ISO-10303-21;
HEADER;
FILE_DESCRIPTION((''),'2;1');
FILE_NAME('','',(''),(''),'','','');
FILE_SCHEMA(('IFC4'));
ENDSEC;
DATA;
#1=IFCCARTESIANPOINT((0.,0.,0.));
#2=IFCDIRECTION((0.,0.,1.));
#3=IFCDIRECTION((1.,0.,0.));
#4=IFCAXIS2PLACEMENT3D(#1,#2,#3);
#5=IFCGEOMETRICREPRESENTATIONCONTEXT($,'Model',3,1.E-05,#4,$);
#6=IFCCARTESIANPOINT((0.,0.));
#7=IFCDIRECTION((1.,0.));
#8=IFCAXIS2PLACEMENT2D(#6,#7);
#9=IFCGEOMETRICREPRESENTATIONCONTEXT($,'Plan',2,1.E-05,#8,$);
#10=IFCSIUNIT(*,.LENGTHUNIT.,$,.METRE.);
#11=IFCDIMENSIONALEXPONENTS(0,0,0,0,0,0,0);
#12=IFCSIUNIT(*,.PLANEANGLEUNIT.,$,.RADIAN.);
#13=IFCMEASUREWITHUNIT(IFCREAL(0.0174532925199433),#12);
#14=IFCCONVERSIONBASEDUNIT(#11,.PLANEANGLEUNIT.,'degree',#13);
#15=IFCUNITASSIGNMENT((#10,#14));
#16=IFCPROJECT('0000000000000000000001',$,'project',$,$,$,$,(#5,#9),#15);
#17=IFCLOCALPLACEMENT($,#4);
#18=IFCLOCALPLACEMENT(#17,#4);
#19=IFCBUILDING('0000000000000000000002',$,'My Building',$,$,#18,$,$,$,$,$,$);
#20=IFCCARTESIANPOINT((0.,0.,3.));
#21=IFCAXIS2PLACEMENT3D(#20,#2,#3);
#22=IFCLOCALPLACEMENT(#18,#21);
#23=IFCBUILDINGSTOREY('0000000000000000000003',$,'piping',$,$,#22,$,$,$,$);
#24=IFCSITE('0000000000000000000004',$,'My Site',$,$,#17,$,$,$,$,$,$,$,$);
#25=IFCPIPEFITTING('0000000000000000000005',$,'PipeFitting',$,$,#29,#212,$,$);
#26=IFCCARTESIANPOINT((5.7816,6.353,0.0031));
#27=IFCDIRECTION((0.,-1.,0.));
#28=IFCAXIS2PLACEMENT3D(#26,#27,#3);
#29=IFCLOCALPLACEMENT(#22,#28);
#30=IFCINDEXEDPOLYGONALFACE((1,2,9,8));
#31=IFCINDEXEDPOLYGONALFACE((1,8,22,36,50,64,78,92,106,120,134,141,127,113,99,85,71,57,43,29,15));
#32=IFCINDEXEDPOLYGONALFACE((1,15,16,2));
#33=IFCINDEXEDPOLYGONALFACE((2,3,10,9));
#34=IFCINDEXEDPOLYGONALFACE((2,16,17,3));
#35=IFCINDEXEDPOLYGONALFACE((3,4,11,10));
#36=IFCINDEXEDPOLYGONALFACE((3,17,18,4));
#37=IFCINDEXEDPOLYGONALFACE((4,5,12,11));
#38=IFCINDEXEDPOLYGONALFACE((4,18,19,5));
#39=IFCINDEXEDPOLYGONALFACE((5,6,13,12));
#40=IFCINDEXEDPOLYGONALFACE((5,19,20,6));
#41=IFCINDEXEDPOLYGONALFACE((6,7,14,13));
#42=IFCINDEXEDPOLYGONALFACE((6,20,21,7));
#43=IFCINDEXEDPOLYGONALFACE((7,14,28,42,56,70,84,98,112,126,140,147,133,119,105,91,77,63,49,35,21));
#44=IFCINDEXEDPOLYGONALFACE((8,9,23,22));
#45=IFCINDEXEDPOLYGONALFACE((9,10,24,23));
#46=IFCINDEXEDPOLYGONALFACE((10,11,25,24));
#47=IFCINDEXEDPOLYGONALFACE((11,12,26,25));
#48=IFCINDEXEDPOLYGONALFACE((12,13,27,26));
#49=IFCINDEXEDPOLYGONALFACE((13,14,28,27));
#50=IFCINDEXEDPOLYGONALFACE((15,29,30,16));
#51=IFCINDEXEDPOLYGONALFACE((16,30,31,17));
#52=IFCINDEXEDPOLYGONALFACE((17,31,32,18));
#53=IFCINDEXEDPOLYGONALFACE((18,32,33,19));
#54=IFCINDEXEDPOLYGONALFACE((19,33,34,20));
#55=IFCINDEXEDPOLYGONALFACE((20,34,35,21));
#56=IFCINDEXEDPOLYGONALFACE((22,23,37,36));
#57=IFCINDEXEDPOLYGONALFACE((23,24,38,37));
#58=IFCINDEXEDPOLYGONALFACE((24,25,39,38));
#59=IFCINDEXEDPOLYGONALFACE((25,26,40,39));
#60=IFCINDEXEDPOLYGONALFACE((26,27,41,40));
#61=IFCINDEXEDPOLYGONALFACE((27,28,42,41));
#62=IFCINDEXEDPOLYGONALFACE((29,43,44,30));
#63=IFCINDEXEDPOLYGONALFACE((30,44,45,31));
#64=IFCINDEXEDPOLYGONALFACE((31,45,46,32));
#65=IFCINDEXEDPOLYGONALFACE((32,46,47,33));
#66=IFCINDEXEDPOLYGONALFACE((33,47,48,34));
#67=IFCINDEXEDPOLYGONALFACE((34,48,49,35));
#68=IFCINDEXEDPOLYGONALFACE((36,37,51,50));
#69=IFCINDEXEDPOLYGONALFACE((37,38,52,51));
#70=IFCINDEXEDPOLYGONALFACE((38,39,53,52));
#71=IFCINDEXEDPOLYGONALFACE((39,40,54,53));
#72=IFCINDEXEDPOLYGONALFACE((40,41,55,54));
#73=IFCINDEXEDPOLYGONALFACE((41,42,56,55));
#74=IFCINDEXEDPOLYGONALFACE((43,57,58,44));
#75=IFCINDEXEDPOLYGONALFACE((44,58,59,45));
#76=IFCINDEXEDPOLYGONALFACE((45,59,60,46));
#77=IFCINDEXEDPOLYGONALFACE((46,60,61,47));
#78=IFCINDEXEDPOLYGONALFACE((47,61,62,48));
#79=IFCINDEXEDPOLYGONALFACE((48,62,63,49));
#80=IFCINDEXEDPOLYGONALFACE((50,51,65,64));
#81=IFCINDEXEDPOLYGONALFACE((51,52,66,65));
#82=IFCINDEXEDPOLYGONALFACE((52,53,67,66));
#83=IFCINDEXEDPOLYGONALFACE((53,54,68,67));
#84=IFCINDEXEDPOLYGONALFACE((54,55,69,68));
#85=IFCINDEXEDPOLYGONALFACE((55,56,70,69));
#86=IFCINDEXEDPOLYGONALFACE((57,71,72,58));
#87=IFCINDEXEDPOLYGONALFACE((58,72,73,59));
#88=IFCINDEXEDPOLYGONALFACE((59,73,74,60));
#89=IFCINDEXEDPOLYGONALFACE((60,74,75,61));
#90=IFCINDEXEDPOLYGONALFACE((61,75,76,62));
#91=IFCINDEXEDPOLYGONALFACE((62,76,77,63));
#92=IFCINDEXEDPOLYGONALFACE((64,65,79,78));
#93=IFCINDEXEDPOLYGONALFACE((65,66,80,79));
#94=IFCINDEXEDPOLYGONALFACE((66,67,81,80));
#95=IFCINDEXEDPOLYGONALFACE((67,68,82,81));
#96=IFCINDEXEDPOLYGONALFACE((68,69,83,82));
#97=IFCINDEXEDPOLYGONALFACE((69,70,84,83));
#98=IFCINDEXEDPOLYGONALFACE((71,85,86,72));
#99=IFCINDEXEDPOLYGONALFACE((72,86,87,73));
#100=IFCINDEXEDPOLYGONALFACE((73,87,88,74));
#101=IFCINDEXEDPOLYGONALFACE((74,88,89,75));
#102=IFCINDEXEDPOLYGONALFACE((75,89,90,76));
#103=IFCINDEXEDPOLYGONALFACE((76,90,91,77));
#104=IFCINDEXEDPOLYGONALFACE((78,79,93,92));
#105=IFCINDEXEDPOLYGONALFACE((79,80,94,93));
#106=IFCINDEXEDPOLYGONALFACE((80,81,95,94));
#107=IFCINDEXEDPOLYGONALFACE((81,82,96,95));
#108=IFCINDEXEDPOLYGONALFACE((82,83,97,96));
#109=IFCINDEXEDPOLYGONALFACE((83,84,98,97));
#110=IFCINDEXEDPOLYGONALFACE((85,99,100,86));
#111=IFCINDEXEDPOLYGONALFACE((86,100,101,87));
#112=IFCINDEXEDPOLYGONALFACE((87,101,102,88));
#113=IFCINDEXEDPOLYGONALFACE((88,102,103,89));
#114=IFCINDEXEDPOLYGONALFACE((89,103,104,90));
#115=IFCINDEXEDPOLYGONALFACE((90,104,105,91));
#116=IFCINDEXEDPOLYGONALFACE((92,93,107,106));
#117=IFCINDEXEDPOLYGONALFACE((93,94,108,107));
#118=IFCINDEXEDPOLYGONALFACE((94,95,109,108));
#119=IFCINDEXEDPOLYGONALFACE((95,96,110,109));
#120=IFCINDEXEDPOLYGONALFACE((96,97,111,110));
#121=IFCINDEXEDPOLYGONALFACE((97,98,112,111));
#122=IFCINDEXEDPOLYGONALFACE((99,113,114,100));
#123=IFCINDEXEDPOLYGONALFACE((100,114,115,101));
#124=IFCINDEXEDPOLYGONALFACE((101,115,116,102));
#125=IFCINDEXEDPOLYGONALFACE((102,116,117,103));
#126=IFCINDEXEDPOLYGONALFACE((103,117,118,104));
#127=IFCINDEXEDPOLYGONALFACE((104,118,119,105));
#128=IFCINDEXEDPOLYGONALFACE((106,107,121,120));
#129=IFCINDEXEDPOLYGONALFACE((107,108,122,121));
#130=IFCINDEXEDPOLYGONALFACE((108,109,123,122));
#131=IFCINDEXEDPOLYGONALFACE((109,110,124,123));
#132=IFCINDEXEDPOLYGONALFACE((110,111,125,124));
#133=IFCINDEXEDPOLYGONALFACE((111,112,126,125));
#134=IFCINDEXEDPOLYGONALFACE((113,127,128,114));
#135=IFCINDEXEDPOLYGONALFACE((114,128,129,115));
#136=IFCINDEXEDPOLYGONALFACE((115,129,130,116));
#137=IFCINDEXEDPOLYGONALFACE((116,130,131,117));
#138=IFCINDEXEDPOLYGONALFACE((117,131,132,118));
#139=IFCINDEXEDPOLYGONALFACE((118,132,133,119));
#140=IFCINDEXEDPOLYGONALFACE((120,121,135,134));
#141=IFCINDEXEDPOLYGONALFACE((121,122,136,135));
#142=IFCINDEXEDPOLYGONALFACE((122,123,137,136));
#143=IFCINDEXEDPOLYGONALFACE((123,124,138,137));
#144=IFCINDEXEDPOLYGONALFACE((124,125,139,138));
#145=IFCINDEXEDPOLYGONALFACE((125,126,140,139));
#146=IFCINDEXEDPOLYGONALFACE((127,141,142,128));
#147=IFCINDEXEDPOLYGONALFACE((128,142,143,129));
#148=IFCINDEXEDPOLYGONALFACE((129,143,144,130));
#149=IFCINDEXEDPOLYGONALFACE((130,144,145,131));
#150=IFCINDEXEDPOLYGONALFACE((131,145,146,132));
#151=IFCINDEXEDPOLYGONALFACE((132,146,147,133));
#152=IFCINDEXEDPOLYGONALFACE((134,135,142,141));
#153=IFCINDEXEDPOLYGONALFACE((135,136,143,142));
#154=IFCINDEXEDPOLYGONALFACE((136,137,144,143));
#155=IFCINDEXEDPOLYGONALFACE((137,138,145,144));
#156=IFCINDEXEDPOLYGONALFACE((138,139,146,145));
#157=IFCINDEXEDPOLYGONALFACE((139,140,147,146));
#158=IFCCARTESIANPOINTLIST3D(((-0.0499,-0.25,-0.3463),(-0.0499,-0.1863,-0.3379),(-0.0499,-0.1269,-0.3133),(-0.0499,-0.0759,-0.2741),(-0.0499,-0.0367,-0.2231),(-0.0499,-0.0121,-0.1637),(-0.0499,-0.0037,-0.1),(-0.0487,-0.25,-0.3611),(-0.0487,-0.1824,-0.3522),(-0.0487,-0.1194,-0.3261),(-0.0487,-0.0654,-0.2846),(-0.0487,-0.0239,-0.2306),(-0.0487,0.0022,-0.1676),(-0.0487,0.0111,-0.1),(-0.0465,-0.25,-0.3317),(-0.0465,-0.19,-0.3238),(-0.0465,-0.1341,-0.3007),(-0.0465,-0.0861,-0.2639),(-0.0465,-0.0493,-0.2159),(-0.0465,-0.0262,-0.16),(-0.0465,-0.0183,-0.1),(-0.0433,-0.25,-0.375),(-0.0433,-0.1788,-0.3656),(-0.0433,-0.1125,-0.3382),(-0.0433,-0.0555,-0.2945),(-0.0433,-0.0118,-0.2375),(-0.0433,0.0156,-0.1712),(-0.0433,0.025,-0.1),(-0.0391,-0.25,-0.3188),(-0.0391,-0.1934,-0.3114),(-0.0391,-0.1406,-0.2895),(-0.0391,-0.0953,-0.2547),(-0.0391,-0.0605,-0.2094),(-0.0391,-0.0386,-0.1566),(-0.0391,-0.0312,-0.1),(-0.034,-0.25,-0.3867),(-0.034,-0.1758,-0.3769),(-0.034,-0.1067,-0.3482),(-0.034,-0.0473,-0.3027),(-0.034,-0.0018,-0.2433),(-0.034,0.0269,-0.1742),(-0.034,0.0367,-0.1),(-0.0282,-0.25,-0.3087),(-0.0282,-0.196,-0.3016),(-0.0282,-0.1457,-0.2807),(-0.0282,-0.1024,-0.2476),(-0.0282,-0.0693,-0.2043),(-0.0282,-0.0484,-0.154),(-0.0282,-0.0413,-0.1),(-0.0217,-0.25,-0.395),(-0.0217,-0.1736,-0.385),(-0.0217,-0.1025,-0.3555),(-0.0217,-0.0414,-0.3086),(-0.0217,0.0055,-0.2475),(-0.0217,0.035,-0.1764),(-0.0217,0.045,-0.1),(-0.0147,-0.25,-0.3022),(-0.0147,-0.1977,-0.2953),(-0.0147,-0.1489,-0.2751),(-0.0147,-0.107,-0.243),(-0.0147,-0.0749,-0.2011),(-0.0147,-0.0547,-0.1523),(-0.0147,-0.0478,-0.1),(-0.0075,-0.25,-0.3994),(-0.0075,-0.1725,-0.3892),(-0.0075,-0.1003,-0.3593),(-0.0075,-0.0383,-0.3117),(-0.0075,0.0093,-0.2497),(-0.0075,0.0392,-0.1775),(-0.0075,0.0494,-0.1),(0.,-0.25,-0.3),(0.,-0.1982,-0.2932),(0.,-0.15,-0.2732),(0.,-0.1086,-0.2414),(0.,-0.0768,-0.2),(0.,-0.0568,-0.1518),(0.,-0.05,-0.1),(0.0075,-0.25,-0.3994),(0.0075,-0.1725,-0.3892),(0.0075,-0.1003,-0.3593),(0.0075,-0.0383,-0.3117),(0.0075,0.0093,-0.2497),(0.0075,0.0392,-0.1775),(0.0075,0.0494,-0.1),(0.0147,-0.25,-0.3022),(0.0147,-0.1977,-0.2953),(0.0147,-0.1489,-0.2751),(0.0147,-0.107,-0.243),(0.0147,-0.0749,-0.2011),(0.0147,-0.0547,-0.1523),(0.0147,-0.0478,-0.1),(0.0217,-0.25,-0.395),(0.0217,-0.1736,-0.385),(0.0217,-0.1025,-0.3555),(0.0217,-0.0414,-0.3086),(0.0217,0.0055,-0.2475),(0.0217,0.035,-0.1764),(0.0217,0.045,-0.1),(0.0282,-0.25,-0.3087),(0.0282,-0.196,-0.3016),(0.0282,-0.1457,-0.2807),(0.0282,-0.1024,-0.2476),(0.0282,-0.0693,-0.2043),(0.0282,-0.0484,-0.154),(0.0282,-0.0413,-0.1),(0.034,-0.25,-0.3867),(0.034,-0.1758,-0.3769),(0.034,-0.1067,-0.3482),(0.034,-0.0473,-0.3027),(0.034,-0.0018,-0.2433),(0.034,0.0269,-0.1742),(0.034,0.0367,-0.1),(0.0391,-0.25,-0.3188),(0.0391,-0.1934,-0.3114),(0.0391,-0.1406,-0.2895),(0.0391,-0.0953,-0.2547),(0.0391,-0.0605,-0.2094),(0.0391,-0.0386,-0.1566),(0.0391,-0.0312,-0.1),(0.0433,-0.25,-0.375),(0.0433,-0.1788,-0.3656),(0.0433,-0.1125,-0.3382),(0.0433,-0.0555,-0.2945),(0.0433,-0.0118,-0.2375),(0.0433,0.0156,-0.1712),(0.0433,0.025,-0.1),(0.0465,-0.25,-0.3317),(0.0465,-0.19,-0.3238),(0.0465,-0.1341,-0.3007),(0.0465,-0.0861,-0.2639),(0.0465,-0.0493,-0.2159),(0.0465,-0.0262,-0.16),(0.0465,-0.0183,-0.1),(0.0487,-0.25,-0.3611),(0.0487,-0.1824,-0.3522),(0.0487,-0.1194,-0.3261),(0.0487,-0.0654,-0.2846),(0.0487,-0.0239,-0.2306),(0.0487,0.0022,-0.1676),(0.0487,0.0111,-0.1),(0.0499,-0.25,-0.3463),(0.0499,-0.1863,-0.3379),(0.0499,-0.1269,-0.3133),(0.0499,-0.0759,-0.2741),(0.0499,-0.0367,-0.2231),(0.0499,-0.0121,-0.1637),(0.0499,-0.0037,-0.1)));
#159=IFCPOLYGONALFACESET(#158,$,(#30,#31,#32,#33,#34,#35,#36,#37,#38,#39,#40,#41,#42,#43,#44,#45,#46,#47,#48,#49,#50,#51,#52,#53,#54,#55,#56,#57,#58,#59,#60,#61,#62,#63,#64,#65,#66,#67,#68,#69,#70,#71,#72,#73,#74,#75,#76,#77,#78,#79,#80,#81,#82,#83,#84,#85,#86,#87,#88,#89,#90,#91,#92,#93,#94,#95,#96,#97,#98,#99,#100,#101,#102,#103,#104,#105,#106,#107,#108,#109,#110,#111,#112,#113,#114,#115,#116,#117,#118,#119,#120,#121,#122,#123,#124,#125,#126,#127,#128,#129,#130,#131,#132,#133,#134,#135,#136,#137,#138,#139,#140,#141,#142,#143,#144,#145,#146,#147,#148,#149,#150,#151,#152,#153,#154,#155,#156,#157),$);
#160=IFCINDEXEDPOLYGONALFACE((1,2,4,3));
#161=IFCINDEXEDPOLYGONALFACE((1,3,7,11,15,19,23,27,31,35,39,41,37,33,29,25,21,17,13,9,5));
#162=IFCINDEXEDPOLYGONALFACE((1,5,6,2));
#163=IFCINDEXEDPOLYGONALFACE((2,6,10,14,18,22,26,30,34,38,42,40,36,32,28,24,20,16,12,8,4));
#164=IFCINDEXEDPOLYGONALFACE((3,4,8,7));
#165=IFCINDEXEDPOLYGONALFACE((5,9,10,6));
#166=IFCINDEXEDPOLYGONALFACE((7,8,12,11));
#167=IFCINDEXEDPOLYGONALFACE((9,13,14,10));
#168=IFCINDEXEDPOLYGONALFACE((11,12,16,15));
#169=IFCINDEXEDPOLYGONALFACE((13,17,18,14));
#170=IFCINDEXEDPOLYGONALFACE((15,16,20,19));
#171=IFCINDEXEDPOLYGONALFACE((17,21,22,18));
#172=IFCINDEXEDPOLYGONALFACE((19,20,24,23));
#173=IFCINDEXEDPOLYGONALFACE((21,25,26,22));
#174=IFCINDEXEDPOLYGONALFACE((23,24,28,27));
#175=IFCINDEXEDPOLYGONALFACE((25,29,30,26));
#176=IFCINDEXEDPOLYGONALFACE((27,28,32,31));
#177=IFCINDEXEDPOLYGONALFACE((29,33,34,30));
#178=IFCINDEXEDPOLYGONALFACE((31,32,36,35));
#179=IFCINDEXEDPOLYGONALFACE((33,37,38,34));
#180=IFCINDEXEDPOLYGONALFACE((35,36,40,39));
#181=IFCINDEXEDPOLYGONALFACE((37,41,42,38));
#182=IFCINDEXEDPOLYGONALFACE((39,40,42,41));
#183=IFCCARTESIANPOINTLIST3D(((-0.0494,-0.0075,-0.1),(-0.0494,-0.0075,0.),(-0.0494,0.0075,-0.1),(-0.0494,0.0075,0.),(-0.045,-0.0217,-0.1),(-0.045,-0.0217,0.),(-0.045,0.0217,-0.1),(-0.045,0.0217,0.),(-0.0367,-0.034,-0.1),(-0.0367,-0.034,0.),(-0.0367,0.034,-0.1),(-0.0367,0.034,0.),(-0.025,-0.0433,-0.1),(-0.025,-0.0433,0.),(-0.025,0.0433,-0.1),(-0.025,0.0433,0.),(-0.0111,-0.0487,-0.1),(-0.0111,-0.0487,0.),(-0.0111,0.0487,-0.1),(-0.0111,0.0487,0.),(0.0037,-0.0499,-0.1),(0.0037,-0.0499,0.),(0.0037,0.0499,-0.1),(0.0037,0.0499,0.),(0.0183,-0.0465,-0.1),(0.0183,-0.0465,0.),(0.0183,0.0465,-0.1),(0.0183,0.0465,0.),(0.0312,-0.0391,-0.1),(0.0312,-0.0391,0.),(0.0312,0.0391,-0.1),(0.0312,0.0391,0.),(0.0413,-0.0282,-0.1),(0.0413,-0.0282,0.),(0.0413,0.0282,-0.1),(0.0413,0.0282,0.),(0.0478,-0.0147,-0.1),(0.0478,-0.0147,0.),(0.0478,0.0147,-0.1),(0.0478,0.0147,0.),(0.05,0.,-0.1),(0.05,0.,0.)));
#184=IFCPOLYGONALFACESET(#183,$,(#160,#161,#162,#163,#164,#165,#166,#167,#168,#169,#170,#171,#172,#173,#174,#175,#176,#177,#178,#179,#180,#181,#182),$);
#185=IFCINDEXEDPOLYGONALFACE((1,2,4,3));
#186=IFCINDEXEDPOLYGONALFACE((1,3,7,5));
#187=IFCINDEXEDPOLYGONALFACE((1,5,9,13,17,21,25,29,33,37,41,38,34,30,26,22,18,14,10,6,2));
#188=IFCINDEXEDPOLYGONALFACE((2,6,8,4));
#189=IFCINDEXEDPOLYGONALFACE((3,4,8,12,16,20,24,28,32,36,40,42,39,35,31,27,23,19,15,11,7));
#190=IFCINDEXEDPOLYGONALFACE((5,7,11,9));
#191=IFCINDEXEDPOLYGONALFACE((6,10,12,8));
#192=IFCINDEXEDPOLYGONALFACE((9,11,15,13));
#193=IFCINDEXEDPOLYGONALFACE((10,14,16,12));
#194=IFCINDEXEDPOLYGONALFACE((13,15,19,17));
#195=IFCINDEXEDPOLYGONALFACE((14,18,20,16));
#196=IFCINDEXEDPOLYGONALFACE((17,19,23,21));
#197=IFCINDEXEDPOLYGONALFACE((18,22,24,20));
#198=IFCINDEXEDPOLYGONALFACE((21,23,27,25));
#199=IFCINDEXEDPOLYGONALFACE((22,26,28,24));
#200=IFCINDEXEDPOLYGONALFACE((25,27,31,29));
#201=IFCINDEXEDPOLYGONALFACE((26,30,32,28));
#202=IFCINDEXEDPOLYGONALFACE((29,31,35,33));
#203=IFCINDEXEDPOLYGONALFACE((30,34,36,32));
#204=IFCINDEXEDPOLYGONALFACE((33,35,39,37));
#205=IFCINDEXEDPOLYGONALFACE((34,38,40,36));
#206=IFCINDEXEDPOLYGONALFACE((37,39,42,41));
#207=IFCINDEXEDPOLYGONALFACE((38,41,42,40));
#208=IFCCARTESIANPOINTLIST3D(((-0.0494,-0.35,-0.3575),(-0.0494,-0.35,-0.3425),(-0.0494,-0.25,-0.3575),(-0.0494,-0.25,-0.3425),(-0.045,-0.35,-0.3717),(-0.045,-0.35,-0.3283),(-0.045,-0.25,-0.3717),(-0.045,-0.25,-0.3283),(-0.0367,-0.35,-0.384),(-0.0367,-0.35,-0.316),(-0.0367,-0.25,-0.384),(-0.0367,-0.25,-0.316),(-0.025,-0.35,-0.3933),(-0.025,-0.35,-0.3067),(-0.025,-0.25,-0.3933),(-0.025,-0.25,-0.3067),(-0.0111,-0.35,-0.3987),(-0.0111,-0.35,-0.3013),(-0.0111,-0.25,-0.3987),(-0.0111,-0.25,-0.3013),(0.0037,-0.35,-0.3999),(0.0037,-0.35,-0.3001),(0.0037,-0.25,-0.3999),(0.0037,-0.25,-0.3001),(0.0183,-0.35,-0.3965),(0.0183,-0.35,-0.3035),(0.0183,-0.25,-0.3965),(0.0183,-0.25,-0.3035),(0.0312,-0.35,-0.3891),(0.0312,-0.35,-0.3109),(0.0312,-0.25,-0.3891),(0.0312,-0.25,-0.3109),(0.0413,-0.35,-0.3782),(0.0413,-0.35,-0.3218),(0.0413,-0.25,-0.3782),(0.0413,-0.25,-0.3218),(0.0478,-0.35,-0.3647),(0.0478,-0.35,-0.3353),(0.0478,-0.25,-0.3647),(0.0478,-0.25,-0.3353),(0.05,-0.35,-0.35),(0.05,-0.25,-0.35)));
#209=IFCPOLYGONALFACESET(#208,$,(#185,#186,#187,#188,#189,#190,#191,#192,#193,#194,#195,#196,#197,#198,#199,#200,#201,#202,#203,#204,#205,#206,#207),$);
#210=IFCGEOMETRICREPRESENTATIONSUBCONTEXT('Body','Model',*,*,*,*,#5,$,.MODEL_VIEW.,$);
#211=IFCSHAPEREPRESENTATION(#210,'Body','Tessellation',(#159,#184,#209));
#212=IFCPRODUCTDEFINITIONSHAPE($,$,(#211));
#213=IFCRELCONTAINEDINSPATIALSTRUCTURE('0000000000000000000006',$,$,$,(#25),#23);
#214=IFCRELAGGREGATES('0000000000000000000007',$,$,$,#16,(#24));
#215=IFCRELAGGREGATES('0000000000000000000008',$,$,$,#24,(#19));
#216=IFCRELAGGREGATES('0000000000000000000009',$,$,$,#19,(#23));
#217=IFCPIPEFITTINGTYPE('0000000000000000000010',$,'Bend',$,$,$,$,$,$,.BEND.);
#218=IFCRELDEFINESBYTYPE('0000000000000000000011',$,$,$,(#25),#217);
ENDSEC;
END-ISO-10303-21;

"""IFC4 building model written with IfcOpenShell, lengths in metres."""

from ifc_helpers import new_model, entity, si_unit, converted_unit, frame, origin_with_axes, origin_2d_with_axis, place, context, subcontext, project, spatial, circle, extrude, source, transform, mapped, type_object, type_shapes, element, save


model = new_model("IFC4")

# Units and contexts
model_context = context("Model", 3, precision=1e-05, world=origin_with_axes())
plan_context = context("Plan", 2, precision=1e-05, world=origin_2d_with_axis())
body_context = subcontext(model_context, "Body", "Model", "MODEL_VIEW")
ifc_project = project(units=[si_unit("LENGTHUNIT", "METRE"), converted_unit("PLANEANGLEUNIT", "degree", entity("IfcReal", 0.0174532925199433), si_unit("PLANEANGLEUNIT", "RADIAN"), dimensions=[0, 0, 0, 0, 0, 0, 0])], contexts=[model_context, plan_context])

# Site, building, storey
site_placement = place(None, origin_with_axes())
site = spatial("IfcSite", under=ifc_project, at=site_placement, Name="My Site")
building_placement = place(site_placement, origin_with_axes())
building = spatial("IfcBuilding", under=site, at=building_placement, Name="My Building")
storey_placement = place(building_placement, frame((0.0, 0.0, 3.0), z_axis=(0.0, 0.0, 1.0), x_axis=(1.0, 0.0, 0.0)))
storey = spatial("IfcBuildingStorey", under=building, at=storey_placement, Name="piping")

# Pipe fitting
pipe_fitting_type = type_object("IfcPipeFittingType", Name="Bend", PredefinedType="BEND")
shared_shape = source(origin_with_axes(), body_context, "Body", "SolidModel", [
    entity("IfcSweptDiskSolid", entity("IfcIndexedPolyCurve", entity("IfcCartesianPointList3D", [[0.0, 0.0, -0.1], [0.0, -0.0732, -0.2768], [0.0, -0.25, -0.35]]), [entity("IfcArcIndex", [1, 2, 3])]), 0.05),
    extrude(circle(Radius=0.05), origin_with_axes(), (0.0, 0.0, -1.0), 0.1),
    extrude(circle(Radius=0.05), frame((0.0, -0.25, -0.35), z_axis=(0.0, -1.0, 0.0), x_axis=(1.0, 0.0, 0.0)), (0.0, 0.0, 1.0), 0.1),
])
type_shapes(pipe_fitting_type, [shared_shape])
for number, where, z_axis, x_axis, name in (
    (1, (5.7816, 6.353, 0.0031), (0.0, -1.0, 0.0), (1.0, 0.0, 0.0), "PipeFitting"),
):
    element("IfcPipeFitting", number, at=place(storey_placement, frame(where, z_axis=z_axis, x_axis=x_axis)), inside=storey, type_object=pipe_fitting_type, Name=name, context=body_context, shape_type="MappedRepresentation", body=[
        mapped(shared_shape, transform((0.0, 0.0, 0.0), x_axis=(1.0, 0.0, 0.0), y_axis=(0.0, 1.0, 0.0), z_axis=(0.0, 0.0, 1.0), scale=1.0)),
    ])

save(model, "model.ifc")
